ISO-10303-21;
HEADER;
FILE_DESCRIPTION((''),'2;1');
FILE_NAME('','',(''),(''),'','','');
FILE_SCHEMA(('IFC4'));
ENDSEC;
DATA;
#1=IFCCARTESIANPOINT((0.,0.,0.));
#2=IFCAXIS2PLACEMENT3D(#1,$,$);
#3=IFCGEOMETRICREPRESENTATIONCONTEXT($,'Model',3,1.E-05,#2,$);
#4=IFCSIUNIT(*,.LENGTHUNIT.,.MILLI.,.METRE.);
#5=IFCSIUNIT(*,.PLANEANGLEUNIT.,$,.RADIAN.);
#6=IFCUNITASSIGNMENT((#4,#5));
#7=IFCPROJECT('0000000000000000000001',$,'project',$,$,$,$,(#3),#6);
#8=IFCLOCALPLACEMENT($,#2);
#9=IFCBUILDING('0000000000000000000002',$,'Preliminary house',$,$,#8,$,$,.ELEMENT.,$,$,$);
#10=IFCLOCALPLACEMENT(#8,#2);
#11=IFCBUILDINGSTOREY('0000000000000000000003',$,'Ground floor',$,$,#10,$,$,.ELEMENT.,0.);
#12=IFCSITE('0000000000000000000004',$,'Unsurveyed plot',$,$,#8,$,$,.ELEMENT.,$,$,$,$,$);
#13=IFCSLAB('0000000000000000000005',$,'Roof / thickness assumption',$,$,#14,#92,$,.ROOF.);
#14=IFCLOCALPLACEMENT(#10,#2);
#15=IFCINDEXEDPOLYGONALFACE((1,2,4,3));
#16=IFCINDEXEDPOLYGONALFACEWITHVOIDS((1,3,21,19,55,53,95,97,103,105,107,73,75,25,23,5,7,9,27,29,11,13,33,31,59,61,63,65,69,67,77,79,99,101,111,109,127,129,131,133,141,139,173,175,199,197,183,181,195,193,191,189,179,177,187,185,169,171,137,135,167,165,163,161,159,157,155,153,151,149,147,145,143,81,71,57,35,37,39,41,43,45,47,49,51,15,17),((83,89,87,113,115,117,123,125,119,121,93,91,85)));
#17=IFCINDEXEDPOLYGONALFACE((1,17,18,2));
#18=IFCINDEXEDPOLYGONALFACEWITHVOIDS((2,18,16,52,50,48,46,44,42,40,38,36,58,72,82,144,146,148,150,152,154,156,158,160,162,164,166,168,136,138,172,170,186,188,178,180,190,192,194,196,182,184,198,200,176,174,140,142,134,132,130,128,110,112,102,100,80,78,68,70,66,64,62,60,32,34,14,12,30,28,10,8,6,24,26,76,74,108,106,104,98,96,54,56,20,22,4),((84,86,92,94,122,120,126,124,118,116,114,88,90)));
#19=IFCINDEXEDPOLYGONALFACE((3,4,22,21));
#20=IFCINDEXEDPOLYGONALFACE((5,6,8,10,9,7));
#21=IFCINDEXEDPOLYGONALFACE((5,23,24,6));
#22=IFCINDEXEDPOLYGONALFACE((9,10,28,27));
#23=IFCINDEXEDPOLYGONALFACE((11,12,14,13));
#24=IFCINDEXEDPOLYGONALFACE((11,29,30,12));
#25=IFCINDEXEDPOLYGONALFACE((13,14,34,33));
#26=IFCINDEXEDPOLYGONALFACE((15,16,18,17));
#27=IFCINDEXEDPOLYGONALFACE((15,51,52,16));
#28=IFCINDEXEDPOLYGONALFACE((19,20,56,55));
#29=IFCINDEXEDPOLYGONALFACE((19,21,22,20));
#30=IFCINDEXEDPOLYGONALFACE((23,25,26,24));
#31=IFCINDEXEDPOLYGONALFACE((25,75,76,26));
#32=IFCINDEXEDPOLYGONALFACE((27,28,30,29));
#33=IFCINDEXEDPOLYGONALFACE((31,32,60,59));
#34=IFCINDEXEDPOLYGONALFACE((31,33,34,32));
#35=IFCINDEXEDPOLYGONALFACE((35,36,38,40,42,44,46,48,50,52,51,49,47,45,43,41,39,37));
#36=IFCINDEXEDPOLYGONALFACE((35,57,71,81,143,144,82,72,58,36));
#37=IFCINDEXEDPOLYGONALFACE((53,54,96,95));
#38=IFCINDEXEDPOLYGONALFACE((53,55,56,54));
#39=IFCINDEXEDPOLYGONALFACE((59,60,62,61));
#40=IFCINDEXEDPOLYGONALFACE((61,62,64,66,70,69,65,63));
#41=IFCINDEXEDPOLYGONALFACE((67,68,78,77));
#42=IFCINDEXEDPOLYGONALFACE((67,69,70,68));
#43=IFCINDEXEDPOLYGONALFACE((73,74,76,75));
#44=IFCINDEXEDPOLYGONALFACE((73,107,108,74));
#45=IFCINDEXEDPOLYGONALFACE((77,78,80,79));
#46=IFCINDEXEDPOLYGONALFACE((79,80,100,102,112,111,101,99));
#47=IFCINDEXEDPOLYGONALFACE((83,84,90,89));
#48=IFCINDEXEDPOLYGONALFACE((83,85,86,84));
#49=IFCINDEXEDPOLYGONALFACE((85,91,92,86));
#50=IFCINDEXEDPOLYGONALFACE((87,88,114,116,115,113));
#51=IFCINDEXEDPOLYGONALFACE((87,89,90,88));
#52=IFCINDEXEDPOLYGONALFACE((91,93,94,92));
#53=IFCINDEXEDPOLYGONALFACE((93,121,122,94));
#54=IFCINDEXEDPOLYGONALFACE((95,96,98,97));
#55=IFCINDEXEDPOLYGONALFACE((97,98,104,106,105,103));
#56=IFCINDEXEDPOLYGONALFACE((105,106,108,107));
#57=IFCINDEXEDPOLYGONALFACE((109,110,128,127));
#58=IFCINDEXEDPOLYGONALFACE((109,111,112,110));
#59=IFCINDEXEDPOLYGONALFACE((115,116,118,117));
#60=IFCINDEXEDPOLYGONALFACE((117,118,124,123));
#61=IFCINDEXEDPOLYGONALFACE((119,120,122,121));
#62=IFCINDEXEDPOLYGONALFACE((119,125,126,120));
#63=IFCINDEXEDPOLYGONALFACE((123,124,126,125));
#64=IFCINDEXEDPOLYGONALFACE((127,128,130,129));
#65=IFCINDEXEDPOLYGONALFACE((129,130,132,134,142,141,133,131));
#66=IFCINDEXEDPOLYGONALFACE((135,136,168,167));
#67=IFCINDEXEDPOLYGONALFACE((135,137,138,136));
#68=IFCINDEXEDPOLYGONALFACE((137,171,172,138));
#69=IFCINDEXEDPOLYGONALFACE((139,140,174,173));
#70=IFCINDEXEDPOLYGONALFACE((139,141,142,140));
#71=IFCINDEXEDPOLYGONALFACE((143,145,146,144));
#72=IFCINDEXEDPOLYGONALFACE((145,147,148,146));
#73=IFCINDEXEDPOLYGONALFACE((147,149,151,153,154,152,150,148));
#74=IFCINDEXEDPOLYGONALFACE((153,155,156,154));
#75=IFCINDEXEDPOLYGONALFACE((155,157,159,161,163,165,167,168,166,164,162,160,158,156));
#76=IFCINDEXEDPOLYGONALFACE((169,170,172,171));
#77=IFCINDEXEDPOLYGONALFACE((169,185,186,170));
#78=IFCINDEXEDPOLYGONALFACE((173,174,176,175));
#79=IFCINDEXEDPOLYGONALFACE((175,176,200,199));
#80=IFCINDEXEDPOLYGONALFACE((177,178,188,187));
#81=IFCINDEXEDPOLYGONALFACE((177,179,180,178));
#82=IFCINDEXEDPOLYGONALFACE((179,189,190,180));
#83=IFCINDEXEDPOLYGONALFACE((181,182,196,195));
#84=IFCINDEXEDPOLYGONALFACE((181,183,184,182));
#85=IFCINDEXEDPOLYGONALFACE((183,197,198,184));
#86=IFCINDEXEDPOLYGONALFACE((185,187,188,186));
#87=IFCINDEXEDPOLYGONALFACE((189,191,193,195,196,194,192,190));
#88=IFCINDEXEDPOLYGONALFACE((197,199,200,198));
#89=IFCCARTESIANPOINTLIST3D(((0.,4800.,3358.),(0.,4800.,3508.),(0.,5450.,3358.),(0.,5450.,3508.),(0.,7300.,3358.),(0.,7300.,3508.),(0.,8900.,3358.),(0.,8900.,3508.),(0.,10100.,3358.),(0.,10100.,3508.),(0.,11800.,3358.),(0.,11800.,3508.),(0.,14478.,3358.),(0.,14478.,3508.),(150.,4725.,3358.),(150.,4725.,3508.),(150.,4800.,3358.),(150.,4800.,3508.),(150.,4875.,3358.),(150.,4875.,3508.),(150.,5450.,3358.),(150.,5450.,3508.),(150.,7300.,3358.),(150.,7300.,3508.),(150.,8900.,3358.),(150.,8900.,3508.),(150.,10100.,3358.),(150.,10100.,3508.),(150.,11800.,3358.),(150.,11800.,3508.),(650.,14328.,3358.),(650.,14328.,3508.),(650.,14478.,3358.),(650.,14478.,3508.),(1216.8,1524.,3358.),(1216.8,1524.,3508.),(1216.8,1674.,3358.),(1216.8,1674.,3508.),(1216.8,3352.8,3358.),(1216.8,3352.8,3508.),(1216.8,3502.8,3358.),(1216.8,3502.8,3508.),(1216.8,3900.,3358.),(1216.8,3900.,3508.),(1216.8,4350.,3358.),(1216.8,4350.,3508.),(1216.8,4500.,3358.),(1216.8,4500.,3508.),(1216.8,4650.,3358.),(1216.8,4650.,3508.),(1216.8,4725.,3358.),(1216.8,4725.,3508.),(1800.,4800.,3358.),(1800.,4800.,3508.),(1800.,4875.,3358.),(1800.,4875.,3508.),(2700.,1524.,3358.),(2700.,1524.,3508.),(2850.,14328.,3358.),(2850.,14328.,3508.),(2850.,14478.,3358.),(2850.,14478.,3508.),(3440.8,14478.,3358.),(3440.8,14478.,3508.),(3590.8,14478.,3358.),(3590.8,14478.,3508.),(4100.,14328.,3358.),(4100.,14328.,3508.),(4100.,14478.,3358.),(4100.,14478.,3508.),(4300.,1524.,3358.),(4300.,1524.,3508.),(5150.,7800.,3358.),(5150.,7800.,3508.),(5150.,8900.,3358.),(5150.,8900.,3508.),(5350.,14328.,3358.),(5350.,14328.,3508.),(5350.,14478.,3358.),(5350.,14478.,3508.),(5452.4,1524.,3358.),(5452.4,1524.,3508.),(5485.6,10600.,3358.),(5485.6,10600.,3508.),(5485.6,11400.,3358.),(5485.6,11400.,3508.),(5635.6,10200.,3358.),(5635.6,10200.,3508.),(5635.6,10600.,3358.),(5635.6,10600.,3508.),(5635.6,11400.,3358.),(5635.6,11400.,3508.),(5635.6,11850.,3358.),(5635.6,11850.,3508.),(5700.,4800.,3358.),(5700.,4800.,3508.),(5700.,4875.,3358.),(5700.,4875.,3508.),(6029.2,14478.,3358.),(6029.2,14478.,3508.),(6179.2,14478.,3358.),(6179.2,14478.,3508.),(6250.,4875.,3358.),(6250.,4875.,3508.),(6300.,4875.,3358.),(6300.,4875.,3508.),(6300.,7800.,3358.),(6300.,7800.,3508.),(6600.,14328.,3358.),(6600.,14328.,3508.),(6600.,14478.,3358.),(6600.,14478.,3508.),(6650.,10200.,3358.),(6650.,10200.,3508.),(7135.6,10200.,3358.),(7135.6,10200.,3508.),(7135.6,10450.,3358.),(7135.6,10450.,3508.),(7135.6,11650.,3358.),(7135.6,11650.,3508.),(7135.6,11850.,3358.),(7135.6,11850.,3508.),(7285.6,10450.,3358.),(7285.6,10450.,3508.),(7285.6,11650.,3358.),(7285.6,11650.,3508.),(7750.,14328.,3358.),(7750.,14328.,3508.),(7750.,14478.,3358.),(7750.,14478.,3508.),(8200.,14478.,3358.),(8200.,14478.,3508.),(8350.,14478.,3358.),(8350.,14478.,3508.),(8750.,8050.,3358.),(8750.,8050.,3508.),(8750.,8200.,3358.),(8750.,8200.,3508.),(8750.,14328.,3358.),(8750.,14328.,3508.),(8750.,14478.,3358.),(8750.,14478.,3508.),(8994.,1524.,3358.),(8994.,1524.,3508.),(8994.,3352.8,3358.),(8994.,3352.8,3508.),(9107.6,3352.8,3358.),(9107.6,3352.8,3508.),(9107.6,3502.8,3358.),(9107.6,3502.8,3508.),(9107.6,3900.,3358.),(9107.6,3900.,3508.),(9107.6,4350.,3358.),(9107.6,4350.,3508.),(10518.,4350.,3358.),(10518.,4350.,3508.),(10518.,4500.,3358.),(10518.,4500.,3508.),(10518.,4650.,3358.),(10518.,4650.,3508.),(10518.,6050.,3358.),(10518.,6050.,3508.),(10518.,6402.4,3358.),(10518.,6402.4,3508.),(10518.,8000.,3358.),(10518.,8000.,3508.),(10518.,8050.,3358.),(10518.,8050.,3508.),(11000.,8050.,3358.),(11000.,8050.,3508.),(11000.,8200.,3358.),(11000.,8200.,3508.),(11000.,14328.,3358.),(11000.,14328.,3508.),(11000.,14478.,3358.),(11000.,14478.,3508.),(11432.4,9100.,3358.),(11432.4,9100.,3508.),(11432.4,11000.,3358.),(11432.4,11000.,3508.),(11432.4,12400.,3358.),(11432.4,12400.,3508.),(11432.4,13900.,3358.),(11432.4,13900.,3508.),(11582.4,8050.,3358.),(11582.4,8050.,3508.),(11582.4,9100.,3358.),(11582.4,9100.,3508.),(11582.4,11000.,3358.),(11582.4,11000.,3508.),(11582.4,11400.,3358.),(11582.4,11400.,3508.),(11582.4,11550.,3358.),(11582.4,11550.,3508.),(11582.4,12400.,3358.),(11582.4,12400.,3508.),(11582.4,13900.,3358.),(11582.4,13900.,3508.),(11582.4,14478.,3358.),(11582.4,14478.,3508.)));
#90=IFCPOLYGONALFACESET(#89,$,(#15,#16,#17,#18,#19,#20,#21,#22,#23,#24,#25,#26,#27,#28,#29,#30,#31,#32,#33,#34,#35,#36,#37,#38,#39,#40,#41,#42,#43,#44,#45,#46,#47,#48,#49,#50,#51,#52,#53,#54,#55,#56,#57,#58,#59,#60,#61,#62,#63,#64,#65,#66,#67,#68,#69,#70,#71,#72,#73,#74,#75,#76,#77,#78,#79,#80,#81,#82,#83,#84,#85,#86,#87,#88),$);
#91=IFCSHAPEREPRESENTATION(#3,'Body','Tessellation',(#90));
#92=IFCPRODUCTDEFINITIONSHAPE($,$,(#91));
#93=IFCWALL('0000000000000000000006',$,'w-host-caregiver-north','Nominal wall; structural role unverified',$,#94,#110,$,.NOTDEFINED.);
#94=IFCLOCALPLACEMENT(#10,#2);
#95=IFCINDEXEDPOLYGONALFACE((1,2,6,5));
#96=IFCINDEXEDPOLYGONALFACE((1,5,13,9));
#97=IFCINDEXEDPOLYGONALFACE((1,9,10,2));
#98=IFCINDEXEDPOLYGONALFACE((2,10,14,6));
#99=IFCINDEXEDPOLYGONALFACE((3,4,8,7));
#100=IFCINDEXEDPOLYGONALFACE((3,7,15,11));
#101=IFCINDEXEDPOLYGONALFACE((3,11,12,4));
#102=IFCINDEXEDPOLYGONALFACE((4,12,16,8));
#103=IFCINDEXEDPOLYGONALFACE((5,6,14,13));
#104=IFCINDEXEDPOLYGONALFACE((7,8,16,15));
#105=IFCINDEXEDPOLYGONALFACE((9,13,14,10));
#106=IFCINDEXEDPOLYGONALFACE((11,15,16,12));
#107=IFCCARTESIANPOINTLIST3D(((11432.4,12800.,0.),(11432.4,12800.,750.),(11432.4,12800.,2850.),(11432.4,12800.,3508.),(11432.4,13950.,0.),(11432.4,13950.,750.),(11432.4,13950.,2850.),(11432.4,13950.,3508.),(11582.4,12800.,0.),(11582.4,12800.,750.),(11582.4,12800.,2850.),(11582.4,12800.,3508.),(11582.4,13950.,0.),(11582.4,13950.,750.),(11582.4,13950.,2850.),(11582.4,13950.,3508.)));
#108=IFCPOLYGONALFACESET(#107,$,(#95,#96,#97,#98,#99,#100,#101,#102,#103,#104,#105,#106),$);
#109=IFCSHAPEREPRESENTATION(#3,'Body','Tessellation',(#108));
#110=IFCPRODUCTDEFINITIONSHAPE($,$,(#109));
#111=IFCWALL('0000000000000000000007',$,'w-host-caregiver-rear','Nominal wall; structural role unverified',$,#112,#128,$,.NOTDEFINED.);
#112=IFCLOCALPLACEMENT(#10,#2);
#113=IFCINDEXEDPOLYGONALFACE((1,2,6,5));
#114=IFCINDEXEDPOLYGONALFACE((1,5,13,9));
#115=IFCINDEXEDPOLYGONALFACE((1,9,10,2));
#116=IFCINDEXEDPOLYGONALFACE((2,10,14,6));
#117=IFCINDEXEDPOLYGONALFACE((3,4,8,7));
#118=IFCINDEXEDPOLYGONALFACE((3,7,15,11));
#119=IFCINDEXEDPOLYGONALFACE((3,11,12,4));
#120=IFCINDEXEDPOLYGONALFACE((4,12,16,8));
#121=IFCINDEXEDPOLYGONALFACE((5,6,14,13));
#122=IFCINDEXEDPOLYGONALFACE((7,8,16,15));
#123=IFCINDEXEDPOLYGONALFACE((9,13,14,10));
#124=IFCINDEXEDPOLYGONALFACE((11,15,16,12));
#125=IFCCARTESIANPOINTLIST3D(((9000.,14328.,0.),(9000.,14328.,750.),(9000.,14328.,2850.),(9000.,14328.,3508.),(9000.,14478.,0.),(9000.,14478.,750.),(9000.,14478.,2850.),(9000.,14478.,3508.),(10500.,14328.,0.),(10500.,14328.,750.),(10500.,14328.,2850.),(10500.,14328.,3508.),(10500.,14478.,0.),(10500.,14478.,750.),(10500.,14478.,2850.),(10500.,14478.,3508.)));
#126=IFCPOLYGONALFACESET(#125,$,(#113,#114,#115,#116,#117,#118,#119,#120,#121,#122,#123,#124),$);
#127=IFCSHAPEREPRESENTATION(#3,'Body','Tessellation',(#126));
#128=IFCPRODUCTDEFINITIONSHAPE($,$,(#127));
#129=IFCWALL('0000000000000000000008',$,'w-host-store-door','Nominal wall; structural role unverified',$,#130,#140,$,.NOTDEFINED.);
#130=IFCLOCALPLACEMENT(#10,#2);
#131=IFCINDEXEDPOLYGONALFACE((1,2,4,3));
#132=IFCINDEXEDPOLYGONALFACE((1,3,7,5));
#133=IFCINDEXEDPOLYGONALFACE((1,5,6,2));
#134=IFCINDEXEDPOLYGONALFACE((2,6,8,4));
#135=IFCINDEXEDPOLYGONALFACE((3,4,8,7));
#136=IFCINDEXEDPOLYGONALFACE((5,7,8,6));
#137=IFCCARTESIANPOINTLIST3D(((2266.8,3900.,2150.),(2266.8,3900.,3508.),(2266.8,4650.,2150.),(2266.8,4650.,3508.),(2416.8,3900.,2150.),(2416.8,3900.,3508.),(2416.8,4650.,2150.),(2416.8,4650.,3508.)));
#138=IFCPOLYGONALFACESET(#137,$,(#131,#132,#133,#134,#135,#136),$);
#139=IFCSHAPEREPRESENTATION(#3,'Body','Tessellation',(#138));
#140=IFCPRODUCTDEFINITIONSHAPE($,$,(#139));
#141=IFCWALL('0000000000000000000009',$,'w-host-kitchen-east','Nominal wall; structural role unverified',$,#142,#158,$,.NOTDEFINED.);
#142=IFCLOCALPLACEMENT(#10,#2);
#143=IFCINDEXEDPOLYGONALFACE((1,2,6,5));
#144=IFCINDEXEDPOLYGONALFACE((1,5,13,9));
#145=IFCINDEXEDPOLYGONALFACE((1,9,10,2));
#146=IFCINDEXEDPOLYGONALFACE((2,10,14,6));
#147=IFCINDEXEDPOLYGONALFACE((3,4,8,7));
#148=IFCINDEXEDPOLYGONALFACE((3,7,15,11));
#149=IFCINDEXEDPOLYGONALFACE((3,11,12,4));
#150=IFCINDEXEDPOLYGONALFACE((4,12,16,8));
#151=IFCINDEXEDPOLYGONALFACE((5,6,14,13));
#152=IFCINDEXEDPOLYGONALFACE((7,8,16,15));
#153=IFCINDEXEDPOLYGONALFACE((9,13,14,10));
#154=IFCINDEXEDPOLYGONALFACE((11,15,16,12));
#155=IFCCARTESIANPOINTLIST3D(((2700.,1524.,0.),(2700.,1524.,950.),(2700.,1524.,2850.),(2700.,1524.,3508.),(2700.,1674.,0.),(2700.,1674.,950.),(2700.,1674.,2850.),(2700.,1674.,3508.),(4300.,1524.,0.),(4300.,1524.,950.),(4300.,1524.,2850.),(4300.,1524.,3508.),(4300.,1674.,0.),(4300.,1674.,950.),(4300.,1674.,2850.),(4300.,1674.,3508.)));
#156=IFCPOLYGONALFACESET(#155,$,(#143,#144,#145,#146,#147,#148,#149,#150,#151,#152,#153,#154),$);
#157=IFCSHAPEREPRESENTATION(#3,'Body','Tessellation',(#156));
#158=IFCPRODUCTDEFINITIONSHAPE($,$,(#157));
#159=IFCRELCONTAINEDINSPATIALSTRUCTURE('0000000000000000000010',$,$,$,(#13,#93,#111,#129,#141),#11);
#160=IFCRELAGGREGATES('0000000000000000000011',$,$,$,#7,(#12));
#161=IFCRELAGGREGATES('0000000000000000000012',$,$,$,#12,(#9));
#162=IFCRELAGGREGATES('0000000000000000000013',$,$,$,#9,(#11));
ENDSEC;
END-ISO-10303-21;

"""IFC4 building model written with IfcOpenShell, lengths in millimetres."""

from ifc_helpers import new_model, si_unit, frame, origin, place, context, project, spatial, polyline, outline, extrude, element, save


model = new_model("IFC4")

# Units and contexts
model_context = context("Model", 3, precision=1e-05, world=origin())
ifc_project = project(units=[si_unit("LENGTHUNIT", "METRE", prefix="MILLI"), si_unit("PLANEANGLEUNIT", "RADIAN")], contexts=[model_context])

# Site, building, storey
placement_1 = place(None, origin())
site = spatial("IfcSite", under=ifc_project, at=placement_1, Name="Unsurveyed plot", CompositionType="ELEMENT")
building = spatial("IfcBuilding", under=site, at=placement_1, Name="Preliminary house", CompositionType="ELEMENT")
placement_2 = place(placement_1, origin())
storey = spatial("IfcBuildingStorey", under=building, at=placement_2, Name="Ground floor", CompositionType="ELEMENT", Elevation=0.0)

# Slab
element("IfcSlab", 1, at=placement_2, inside=storey, Name="Roof / thickness assumption", PredefinedType="ROOF", context=model_context, shape_type="SweptSolid", body=[
    extrude(outline(polyline([(1216.8, 3900.0), (1216.8, 4350.0), (1216.8, 4500.0), (1216.8, 4650.0), (1216.8, 4725.0), (150.0, 4725.0), (150.0, 4800.0), (0.0, 4800.0), (0.0, 5450.0), (150.0, 5450.0), (150.0, 4875.0), (1800.0, 4875.0), (1800.0, 4800.0), (5700.0, 4800.0), (5700.0, 4875.0), (6250.0, 4875.0), (6300.0, 4875.0), (6300.0, 7800.0), (5150.0, 7800.0), (5150.0, 8900.0), (150.0, 8900.0), (150.0, 7300.0), (0.0, 7300.0), (0.0, 8900.0), (0.0, 10100.0), (150.0, 10100.0), (150.0, 11800.0), (0.0, 11800.0), (0.0, 14478.0), (650.0, 14478.0), (650.0, 14328.0), (2850.0, 14328.0), (2850.0, 14478.0), (3440.8, 14478.0), (3590.8, 14478.0), (4100.0, 14478.0), (4100.0, 14328.0), (5350.0, 14328.0), (5350.0, 14478.0), (6029.2, 14478.0), (6179.2, 14478.0), (6600.0, 14478.0), (6600.0, 14328.0), (7750.0, 14328.0), (7750.0, 14478.0), (8200.0, 14478.0), (8350.0, 14478.0), (8750.0, 14478.0), (8750.0, 14328.0), (11000.0, 14328.0), (11000.0, 14478.0), (11582.4, 14478.0), (11582.4, 13900.0), (11432.4, 13900.0), (11432.4, 12400.0), (11582.4, 12400.0), (11582.4, 11550.0), (11582.4, 11400.0), (11582.4, 11000.0), (11432.4, 11000.0), (11432.4, 9100.0), (11582.4, 9100.0), (11582.4, 8050.0), (11000.0, 8050.0), (11000.0, 8200.0), (8750.0, 8200.0), (8750.0, 8050.0), (10518.0, 8050.0), (10518.0, 8000.0), (10518.0, 6402.4), (10518.0, 6050.0), (10518.0, 4650.0), (10518.0, 4500.0), (10518.0, 4350.0), (9107.6, 4350.0), (9107.6, 3900.0), (9107.6, 3502.8), (9107.6, 3352.8), (8994.0, 3352.8), (8994.0, 1524.0), (5452.4, 1524.0), (4300.0, 1524.0), (2700.0, 1524.0), (1216.8, 1524.0), (1216.8, 1674.0), (1216.8, 3352.8), (1216.8, 3502.8), (1216.8, 3900.0)]), holes=[polyline([(7135.6, 11650.0), (7135.6, 11850.0), (5635.6, 11850.0), (5635.6, 11400.0), (5485.6, 11400.0), (5485.6, 10600.0), (5635.6, 10600.0), (5635.6, 10200.0), (6650.0, 10200.0), (7135.6, 10200.0), (7135.6, 10450.0), (7285.6, 10450.0), (7285.6, 11650.0), (7135.6, 11650.0)])]), frame((0.0, 0.0, 3358.0)), (0.0, 0.0, 1.0), 150.0),
])

# Walls, openings
wall_1 = element("IfcWall", 2, at=placement_2, inside=storey, Name="w-host-caregiver-north", Description="Nominal wall; structural role unverified", PredefinedType="NOTDEFINED", context=model_context, shape_type="SweptSolid", body=[
    extrude(outline(polyline([(11582.4, 12800.0), (11582.4, 13950.0), (11432.4, 13950.0), (11432.4, 12800.0), (11582.4, 12800.0)])), origin(), (0.0, 0.0, 1.0), 3508.0),
])
element("IfcOpeningElement", 3, at=placement_2, cuts=wall_1, PredefinedType="OPENING", context=model_context, shape_type="SweptSolid", body=[
    extrude(outline(polyline([(11957.4, 12800.0), (11957.4, 13950.0), (11057.4, 13950.0), (11057.4, 12800.0), (11957.4, 12800.0)])), frame((0.0, 0.0, 750.0)), (0.0, 0.0, 1.0), 2100.0),
])
wall_2 = element("IfcWall", 4, at=placement_2, inside=storey, Name="w-host-caregiver-rear", Description="Nominal wall; structural role unverified", PredefinedType="NOTDEFINED", context=model_context, shape_type="SweptSolid", body=[
    extrude(outline(polyline([(9000.0, 14328.0), (10500.0, 14328.0), (10500.0, 14478.0), (9000.0, 14478.0), (9000.0, 14328.0)])), origin(), (0.0, 0.0, 1.0), 3508.0),
])
element("IfcOpeningElement", 5, at=placement_2, cuts=wall_2, PredefinedType="OPENING", context=model_context, shape_type="SweptSolid", body=[
    extrude(outline(polyline([(9000.0, 13953.0), (10500.0, 13953.0), (10500.0, 14853.0), (9000.0, 14853.0), (9000.0, 13953.0)])), frame((0.0, 0.0, 750.0)), (0.0, 0.0, 1.0), 2100.0),
])
wall_3 = element("IfcWall", 6, at=placement_2, inside=storey, Name="w-host-store-door", Description="Nominal wall; structural role unverified", PredefinedType="NOTDEFINED", context=model_context, shape_type="SweptSolid", body=[
    extrude(outline(polyline([(2416.8, 3900.0), (2416.8, 4650.0), (2266.8, 4650.0), (2266.8, 3900.0), (2416.8, 3900.0)])), origin(), (0.0, 0.0, 1.0), 3508.0),
])
element("IfcOpeningElement", 7, at=placement_2, cuts=wall_3, PredefinedType="OPENING", context=model_context, shape_type="SweptSolid", body=[
    extrude(outline(polyline([(2791.8, 3900.0), (2791.8, 4650.0), (1891.8, 4650.0), (1891.8, 3900.0), (2791.8, 3900.0)])), origin(), (0.0, 0.0, 1.0), 2150.0),
])
wall_4 = element("IfcWall", 8, at=placement_2, inside=storey, Name="w-host-kitchen-east", Description="Nominal wall; structural role unverified", PredefinedType="NOTDEFINED", context=model_context, shape_type="SweptSolid", body=[
    extrude(outline(polyline([(2700.0, 1524.0), (4300.0, 1524.0), (4300.0, 1674.0), (2700.0, 1674.0), (2700.0, 1524.0)])), origin(), (0.0, 0.0, 1.0), 3508.0),
])
element("IfcOpeningElement", 9, at=placement_2, cuts=wall_4, PredefinedType="OPENING", context=model_context, shape_type="SweptSolid", body=[
    extrude(outline(polyline([(2700.0, 1149.0), (4300.0, 1149.0), (4300.0, 2049.0), (2700.0, 2049.0), (2700.0, 1149.0)])), frame((0.0, 0.0, 950.0)), (0.0, 0.0, 1.0), 1900.0),
])

save(model, "model.ifc")
